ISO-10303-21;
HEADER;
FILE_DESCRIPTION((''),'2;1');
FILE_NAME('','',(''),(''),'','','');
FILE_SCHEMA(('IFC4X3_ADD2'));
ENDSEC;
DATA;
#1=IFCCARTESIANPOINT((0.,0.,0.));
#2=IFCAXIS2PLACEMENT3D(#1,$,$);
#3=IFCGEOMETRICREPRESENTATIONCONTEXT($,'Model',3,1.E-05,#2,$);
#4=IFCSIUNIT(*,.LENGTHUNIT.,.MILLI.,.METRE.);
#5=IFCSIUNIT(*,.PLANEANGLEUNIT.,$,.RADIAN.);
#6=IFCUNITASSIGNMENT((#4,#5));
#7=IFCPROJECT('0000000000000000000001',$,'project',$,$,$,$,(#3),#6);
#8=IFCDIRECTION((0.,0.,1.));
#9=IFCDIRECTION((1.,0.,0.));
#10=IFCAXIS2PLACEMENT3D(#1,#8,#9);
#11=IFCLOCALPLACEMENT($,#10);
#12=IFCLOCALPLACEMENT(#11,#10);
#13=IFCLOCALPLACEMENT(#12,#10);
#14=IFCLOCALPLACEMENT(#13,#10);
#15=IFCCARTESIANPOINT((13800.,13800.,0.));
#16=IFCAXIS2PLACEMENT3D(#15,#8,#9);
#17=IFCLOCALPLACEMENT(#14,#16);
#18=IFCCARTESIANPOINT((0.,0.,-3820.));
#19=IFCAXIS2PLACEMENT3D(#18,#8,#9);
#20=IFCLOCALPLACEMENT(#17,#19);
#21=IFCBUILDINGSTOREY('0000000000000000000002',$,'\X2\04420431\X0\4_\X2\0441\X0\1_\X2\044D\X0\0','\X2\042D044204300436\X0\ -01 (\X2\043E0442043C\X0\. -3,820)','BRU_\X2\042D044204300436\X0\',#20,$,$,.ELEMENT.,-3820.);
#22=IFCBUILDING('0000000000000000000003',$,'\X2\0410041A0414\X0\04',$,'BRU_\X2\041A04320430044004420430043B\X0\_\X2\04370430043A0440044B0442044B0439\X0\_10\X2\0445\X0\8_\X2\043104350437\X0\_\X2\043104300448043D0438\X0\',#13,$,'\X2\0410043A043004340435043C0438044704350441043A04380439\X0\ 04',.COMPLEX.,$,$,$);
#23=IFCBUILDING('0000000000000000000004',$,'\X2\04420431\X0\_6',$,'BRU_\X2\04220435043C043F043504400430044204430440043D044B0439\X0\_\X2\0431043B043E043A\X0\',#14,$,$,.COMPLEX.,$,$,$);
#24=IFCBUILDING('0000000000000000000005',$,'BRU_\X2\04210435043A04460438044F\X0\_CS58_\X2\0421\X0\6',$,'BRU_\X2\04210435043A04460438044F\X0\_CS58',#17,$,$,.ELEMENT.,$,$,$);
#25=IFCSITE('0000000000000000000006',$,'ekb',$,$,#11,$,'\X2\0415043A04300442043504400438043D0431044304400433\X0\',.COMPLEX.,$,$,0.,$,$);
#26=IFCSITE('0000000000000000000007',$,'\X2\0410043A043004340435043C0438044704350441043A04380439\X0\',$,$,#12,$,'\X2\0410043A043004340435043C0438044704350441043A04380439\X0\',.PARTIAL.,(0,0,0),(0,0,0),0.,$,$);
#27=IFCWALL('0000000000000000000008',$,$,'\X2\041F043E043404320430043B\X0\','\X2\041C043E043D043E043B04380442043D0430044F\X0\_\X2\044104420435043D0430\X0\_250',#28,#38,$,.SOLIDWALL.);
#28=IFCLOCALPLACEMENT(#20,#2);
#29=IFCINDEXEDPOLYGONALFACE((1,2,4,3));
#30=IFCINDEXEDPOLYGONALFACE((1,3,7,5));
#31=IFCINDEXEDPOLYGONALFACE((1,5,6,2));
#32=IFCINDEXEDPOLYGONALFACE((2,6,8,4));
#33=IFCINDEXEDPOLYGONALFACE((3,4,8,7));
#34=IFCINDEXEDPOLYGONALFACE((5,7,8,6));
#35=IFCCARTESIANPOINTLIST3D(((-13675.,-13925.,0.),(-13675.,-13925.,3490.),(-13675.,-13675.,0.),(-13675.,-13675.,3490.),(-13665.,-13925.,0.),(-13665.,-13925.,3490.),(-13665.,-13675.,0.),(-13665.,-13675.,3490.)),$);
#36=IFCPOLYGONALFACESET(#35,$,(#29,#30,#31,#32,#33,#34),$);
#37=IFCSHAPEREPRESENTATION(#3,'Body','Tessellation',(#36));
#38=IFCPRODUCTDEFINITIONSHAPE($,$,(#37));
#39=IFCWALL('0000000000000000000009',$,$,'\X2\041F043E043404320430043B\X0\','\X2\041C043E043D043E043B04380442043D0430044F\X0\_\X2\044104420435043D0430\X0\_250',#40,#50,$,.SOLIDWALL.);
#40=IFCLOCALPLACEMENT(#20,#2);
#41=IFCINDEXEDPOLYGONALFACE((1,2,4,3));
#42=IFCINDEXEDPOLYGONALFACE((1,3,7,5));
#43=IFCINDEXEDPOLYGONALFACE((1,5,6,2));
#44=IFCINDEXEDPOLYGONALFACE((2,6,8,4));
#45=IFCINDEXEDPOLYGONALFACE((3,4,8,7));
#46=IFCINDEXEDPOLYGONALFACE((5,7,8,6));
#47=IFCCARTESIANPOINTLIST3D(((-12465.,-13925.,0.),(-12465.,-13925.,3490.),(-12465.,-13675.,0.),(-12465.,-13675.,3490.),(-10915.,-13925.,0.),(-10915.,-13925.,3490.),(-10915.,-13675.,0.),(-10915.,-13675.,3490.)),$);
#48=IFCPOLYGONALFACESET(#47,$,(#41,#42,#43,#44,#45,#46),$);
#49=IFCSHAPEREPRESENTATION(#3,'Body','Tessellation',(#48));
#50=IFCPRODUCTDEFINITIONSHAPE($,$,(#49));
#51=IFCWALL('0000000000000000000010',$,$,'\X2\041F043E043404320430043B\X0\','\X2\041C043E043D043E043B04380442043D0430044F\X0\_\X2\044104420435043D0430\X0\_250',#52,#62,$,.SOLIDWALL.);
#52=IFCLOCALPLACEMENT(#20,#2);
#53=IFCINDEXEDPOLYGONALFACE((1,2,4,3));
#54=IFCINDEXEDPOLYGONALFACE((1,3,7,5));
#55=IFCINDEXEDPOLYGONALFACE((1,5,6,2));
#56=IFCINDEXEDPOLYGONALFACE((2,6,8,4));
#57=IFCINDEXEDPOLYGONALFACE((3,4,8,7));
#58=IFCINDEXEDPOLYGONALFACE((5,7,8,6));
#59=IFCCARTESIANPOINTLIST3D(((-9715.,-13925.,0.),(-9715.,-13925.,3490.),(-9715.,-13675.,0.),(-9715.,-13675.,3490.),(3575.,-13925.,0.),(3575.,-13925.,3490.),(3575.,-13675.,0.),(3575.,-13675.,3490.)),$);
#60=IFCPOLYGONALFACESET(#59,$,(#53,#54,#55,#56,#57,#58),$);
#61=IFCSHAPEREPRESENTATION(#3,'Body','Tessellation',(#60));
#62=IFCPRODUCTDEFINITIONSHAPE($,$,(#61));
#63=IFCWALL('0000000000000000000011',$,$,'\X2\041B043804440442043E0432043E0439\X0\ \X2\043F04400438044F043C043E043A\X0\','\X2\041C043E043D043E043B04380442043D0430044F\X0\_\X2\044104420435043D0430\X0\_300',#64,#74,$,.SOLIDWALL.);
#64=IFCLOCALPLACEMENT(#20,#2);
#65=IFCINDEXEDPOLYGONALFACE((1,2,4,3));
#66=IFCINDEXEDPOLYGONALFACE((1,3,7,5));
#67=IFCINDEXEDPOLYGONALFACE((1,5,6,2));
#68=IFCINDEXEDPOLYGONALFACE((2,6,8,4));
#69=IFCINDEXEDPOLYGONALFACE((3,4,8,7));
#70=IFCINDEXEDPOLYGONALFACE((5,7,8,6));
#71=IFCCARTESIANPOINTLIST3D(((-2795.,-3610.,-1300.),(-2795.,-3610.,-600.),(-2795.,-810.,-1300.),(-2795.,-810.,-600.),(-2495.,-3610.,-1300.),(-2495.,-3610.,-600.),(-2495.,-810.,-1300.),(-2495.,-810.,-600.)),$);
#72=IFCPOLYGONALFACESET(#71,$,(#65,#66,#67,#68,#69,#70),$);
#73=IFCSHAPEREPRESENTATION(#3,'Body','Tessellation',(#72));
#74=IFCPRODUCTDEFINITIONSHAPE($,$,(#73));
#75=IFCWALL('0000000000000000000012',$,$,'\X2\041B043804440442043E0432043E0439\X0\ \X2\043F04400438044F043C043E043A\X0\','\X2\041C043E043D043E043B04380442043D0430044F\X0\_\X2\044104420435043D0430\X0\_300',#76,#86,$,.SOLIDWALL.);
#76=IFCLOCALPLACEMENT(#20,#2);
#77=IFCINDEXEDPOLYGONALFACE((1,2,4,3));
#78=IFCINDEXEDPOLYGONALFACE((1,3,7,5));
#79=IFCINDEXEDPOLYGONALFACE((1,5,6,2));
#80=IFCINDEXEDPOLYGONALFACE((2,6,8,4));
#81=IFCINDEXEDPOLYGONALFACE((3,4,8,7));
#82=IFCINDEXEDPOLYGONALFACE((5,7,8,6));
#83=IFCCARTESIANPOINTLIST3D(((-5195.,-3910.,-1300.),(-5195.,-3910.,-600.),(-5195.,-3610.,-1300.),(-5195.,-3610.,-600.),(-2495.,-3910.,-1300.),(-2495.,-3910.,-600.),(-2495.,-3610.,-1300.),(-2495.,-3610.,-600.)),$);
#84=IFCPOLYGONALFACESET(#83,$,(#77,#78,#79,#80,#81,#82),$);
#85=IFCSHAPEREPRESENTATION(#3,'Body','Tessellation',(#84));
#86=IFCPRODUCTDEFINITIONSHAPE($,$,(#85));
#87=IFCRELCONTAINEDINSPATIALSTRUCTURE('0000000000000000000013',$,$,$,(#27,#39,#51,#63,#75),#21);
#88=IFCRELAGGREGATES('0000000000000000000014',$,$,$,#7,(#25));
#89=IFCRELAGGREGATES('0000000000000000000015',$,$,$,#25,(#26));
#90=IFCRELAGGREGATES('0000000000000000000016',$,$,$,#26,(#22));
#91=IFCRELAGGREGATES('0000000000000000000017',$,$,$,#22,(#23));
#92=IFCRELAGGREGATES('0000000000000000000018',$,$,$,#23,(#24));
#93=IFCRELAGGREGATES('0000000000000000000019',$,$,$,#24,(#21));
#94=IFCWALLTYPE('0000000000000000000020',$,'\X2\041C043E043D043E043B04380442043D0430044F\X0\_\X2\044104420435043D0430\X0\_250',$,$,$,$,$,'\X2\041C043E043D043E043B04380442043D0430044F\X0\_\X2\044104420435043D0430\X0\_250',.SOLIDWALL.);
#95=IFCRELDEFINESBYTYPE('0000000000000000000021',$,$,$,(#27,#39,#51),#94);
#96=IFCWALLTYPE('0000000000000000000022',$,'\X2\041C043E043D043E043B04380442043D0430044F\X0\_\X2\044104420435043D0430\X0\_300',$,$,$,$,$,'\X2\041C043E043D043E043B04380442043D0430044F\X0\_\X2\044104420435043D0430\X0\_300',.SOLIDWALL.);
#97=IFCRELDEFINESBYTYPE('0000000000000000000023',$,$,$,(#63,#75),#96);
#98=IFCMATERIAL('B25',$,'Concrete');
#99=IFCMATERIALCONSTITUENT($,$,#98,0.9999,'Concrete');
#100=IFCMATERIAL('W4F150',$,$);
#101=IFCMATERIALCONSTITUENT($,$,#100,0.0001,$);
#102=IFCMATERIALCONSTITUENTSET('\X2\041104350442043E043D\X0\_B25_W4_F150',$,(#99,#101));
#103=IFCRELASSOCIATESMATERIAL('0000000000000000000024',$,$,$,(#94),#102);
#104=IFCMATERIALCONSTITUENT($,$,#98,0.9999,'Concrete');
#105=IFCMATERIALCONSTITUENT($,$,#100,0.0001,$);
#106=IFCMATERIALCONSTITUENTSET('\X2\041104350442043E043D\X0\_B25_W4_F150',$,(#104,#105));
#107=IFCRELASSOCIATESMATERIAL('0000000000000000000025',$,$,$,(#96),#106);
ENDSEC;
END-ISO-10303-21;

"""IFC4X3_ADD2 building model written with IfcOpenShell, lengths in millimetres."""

from ifc_helpers import new_model, si_unit, frame, origin, origin_with_axes, origin_2d_with_axis, place, context, project, spatial, rectangle, extrude, material, constituent, constituent_set, type_object, element, save


model = new_model("IFC4X3_ADD2")

# Units and contexts
model_context = context("Model", 3, precision=1e-05, world=origin())
ifc_project = project(units=[si_unit("LENGTHUNIT", "METRE", prefix="MILLI"), si_unit("PLANEANGLEUNIT", "RADIAN")], contexts=[model_context])

# Sites, buildings, storey
site_1_placement = place(None, origin_with_axes())
site_1 = spatial("IfcSite", under=ifc_project, at=site_1_placement, Name="ekb", LongName="Екатеринбург", CompositionType="COMPLEX", RefElevation=0.0)
site_2_placement = place(site_1_placement, origin_with_axes())
site_2 = spatial("IfcSite", under=site_1, at=site_2_placement, Name="Академический", LongName="Академический", CompositionType="PARTIAL", RefLatitude=(0, 0, 0), RefLongitude=(0, 0, 0), RefElevation=0.0)
building_1_placement = place(site_2_placement, origin_with_axes())
building_1 = spatial("IfcBuilding", under=site_2, at=building_1_placement, Name="АКД04", ObjectType="BRU_Квартал_закрытый_10х8_без_башни", LongName="Академический 04", CompositionType="COMPLEX")
building_2_placement = place(building_1_placement, origin_with_axes())
building_2 = spatial("IfcBuilding", under=building_1, at=building_2_placement, Name="тб_6", ObjectType="BRU_Температурный_блок", CompositionType="COMPLEX")
building_3_placement = place(building_2_placement, frame((13800.0, 13800.0, 0.0), z_axis=(0.0, 0.0, 1.0), x_axis=(1.0, 0.0, 0.0)))
building_3 = spatial("IfcBuilding", under=building_2, at=building_3_placement, Name="BRU_Секция_CS58_С6", ObjectType="BRU_Секция_CS58", CompositionType="ELEMENT")
storey_placement = place(building_3_placement, frame((0.0, 0.0, -3820.0), z_axis=(0.0, 0.0, 1.0), x_axis=(1.0, 0.0, 0.0)))
storey = spatial("IfcBuildingStorey", under=building_3, at=storey_placement, Name="тб4_с1_э0", Description="Этаж -01 (отм. -3,820)", ObjectType="BRU_Этаж", CompositionType="ELEMENT", Elevation=-3820.0)

# Shared definitions
ifc_material_1 = material(Name="B25", Category="Concrete")
ifc_material_2 = material(Name="W4F150")

# Walls
ifc_constituent_1 = constituent(ifc_material_1, Category="Concrete", fraction=0.9999)
ifc_constituent_2 = constituent(ifc_material_2, fraction=0.0001)
ifc_constituent_set_1 = constituent_set(constituents=[ifc_constituent_1, ifc_constituent_2], Name="Бетон_B25_W4_F150")
wall_type_1 = type_object("IfcWallType", Name="Монолитная_стена_250", ElementType="Монолитная_стена_250", PredefinedType="SOLIDWALL", material=ifc_constituent_set_1)
wall_1_placement = place(storey_placement, frame((-13675.0, -13800.0, 0.0), z_axis=(0.0, 0.0, 1.0), x_axis=(1.0, 0.0, 0.0)))
element("IfcWall", 1, at=wall_1_placement, inside=storey, type_object=wall_type_1, Description="Подвал", ObjectType="Монолитная_стена_250", PredefinedType="SOLIDWALL", context=model_context, shape_type="SweptSolid", body=[
    extrude(rectangle(XDim=10.0, YDim=250.0, at=origin_2d_with_axis()), frame((5.0, 0.0, 0.0), z_axis=(0.0, 0.0, 1.0), x_axis=(1.0, 0.0, 0.0)), (0.0, 0.0, 1.0), 3490.0),
])
wall_2_placement = place(storey_placement, frame((-12465.0, -13800.0, 0.0), z_axis=(0.0, 0.0, 1.0), x_axis=(1.0, 0.0, 0.0)))
element("IfcWall", 2, at=wall_2_placement, inside=storey, type_object=wall_type_1, Description="Подвал", ObjectType="Монолитная_стена_250", PredefinedType="SOLIDWALL", context=model_context, shape_type="SweptSolid", body=[
    extrude(rectangle(XDim=1550.0, YDim=250.0, at=origin_2d_with_axis()), frame((775.0, 0.0, 0.0), z_axis=(0.0, 0.0, 1.0), x_axis=(1.0, 0.0, 0.0)), (0.0, 0.0, 1.0), 3490.0),
])
wall_3_placement = place(storey_placement, frame((-9715.0, -13800.0, 0.0), z_axis=(0.0, 0.0, 1.0), x_axis=(1.0, 0.0, 0.0)))
element("IfcWall", 3, at=wall_3_placement, inside=storey, type_object=wall_type_1, Description="Подвал", ObjectType="Монолитная_стена_250", PredefinedType="SOLIDWALL", context=model_context, shape_type="SweptSolid", body=[
    extrude(rectangle(XDim=13290.0, YDim=250.0, at=origin_2d_with_axis()), frame((6645.0, 0.0, 0.0), z_axis=(0.0, 0.0, 1.0), x_axis=(1.0, 0.0, 0.0)), (0.0, 0.0, 1.0), 3490.0),
])
ifc_constituent_3 = constituent(ifc_material_1, Category="Concrete", fraction=0.9999)
ifc_constituent_4 = constituent(ifc_material_2, fraction=0.0001)
ifc_constituent_set_2 = constituent_set(constituents=[ifc_constituent_3, ifc_constituent_4], Name="Бетон_B25_W4_F150")
wall_type_2 = type_object("IfcWallType", Name="Монолитная_стена_300", ElementType="Монолитная_стена_300", PredefinedType="SOLIDWALL", material=ifc_constituent_set_2)
wall_4_placement = place(storey_placement, frame((-2645.0, -3610.0, -1300.0), z_axis=(0.0, 0.0, 1.0), x_axis=(0.0, 1.0, 0.0)))
element("IfcWall", 4, at=wall_4_placement, inside=storey, type_object=wall_type_2, Description="Лифтовой приямок", ObjectType="Монолитная_стена_300", PredefinedType="SOLIDWALL", context=model_context, shape_type="SweptSolid", body=[
    extrude(rectangle(XDim=2800.0, YDim=300.0, at=origin_2d_with_axis()), frame((1400.0, 0.0, 0.0), z_axis=(0.0, 0.0, 1.0), x_axis=(1.0, 0.0, 0.0)), (0.0, 0.0, 1.0), 700.0),
])
wall_5_placement = place(storey_placement, frame((-5195.0, -3760.0, -1300.0), z_axis=(0.0, 0.0, 1.0), x_axis=(1.0, 0.0, 0.0)))
element("IfcWall", 5, at=wall_5_placement, inside=storey, type_object=wall_type_2, Description="Лифтовой приямок", ObjectType="Монолитная_стена_300", PredefinedType="SOLIDWALL", context=model_context, shape_type="SweptSolid", body=[
    extrude(rectangle(XDim=2700.0, YDim=300.0, at=origin_2d_with_axis()), frame((1350.0, 0.0, 0.0), z_axis=(0.0, 0.0, 1.0), x_axis=(1.0, 0.0, 0.0)), (0.0, 0.0, 1.0), 700.0),
])

save(model, "model.ifc")
